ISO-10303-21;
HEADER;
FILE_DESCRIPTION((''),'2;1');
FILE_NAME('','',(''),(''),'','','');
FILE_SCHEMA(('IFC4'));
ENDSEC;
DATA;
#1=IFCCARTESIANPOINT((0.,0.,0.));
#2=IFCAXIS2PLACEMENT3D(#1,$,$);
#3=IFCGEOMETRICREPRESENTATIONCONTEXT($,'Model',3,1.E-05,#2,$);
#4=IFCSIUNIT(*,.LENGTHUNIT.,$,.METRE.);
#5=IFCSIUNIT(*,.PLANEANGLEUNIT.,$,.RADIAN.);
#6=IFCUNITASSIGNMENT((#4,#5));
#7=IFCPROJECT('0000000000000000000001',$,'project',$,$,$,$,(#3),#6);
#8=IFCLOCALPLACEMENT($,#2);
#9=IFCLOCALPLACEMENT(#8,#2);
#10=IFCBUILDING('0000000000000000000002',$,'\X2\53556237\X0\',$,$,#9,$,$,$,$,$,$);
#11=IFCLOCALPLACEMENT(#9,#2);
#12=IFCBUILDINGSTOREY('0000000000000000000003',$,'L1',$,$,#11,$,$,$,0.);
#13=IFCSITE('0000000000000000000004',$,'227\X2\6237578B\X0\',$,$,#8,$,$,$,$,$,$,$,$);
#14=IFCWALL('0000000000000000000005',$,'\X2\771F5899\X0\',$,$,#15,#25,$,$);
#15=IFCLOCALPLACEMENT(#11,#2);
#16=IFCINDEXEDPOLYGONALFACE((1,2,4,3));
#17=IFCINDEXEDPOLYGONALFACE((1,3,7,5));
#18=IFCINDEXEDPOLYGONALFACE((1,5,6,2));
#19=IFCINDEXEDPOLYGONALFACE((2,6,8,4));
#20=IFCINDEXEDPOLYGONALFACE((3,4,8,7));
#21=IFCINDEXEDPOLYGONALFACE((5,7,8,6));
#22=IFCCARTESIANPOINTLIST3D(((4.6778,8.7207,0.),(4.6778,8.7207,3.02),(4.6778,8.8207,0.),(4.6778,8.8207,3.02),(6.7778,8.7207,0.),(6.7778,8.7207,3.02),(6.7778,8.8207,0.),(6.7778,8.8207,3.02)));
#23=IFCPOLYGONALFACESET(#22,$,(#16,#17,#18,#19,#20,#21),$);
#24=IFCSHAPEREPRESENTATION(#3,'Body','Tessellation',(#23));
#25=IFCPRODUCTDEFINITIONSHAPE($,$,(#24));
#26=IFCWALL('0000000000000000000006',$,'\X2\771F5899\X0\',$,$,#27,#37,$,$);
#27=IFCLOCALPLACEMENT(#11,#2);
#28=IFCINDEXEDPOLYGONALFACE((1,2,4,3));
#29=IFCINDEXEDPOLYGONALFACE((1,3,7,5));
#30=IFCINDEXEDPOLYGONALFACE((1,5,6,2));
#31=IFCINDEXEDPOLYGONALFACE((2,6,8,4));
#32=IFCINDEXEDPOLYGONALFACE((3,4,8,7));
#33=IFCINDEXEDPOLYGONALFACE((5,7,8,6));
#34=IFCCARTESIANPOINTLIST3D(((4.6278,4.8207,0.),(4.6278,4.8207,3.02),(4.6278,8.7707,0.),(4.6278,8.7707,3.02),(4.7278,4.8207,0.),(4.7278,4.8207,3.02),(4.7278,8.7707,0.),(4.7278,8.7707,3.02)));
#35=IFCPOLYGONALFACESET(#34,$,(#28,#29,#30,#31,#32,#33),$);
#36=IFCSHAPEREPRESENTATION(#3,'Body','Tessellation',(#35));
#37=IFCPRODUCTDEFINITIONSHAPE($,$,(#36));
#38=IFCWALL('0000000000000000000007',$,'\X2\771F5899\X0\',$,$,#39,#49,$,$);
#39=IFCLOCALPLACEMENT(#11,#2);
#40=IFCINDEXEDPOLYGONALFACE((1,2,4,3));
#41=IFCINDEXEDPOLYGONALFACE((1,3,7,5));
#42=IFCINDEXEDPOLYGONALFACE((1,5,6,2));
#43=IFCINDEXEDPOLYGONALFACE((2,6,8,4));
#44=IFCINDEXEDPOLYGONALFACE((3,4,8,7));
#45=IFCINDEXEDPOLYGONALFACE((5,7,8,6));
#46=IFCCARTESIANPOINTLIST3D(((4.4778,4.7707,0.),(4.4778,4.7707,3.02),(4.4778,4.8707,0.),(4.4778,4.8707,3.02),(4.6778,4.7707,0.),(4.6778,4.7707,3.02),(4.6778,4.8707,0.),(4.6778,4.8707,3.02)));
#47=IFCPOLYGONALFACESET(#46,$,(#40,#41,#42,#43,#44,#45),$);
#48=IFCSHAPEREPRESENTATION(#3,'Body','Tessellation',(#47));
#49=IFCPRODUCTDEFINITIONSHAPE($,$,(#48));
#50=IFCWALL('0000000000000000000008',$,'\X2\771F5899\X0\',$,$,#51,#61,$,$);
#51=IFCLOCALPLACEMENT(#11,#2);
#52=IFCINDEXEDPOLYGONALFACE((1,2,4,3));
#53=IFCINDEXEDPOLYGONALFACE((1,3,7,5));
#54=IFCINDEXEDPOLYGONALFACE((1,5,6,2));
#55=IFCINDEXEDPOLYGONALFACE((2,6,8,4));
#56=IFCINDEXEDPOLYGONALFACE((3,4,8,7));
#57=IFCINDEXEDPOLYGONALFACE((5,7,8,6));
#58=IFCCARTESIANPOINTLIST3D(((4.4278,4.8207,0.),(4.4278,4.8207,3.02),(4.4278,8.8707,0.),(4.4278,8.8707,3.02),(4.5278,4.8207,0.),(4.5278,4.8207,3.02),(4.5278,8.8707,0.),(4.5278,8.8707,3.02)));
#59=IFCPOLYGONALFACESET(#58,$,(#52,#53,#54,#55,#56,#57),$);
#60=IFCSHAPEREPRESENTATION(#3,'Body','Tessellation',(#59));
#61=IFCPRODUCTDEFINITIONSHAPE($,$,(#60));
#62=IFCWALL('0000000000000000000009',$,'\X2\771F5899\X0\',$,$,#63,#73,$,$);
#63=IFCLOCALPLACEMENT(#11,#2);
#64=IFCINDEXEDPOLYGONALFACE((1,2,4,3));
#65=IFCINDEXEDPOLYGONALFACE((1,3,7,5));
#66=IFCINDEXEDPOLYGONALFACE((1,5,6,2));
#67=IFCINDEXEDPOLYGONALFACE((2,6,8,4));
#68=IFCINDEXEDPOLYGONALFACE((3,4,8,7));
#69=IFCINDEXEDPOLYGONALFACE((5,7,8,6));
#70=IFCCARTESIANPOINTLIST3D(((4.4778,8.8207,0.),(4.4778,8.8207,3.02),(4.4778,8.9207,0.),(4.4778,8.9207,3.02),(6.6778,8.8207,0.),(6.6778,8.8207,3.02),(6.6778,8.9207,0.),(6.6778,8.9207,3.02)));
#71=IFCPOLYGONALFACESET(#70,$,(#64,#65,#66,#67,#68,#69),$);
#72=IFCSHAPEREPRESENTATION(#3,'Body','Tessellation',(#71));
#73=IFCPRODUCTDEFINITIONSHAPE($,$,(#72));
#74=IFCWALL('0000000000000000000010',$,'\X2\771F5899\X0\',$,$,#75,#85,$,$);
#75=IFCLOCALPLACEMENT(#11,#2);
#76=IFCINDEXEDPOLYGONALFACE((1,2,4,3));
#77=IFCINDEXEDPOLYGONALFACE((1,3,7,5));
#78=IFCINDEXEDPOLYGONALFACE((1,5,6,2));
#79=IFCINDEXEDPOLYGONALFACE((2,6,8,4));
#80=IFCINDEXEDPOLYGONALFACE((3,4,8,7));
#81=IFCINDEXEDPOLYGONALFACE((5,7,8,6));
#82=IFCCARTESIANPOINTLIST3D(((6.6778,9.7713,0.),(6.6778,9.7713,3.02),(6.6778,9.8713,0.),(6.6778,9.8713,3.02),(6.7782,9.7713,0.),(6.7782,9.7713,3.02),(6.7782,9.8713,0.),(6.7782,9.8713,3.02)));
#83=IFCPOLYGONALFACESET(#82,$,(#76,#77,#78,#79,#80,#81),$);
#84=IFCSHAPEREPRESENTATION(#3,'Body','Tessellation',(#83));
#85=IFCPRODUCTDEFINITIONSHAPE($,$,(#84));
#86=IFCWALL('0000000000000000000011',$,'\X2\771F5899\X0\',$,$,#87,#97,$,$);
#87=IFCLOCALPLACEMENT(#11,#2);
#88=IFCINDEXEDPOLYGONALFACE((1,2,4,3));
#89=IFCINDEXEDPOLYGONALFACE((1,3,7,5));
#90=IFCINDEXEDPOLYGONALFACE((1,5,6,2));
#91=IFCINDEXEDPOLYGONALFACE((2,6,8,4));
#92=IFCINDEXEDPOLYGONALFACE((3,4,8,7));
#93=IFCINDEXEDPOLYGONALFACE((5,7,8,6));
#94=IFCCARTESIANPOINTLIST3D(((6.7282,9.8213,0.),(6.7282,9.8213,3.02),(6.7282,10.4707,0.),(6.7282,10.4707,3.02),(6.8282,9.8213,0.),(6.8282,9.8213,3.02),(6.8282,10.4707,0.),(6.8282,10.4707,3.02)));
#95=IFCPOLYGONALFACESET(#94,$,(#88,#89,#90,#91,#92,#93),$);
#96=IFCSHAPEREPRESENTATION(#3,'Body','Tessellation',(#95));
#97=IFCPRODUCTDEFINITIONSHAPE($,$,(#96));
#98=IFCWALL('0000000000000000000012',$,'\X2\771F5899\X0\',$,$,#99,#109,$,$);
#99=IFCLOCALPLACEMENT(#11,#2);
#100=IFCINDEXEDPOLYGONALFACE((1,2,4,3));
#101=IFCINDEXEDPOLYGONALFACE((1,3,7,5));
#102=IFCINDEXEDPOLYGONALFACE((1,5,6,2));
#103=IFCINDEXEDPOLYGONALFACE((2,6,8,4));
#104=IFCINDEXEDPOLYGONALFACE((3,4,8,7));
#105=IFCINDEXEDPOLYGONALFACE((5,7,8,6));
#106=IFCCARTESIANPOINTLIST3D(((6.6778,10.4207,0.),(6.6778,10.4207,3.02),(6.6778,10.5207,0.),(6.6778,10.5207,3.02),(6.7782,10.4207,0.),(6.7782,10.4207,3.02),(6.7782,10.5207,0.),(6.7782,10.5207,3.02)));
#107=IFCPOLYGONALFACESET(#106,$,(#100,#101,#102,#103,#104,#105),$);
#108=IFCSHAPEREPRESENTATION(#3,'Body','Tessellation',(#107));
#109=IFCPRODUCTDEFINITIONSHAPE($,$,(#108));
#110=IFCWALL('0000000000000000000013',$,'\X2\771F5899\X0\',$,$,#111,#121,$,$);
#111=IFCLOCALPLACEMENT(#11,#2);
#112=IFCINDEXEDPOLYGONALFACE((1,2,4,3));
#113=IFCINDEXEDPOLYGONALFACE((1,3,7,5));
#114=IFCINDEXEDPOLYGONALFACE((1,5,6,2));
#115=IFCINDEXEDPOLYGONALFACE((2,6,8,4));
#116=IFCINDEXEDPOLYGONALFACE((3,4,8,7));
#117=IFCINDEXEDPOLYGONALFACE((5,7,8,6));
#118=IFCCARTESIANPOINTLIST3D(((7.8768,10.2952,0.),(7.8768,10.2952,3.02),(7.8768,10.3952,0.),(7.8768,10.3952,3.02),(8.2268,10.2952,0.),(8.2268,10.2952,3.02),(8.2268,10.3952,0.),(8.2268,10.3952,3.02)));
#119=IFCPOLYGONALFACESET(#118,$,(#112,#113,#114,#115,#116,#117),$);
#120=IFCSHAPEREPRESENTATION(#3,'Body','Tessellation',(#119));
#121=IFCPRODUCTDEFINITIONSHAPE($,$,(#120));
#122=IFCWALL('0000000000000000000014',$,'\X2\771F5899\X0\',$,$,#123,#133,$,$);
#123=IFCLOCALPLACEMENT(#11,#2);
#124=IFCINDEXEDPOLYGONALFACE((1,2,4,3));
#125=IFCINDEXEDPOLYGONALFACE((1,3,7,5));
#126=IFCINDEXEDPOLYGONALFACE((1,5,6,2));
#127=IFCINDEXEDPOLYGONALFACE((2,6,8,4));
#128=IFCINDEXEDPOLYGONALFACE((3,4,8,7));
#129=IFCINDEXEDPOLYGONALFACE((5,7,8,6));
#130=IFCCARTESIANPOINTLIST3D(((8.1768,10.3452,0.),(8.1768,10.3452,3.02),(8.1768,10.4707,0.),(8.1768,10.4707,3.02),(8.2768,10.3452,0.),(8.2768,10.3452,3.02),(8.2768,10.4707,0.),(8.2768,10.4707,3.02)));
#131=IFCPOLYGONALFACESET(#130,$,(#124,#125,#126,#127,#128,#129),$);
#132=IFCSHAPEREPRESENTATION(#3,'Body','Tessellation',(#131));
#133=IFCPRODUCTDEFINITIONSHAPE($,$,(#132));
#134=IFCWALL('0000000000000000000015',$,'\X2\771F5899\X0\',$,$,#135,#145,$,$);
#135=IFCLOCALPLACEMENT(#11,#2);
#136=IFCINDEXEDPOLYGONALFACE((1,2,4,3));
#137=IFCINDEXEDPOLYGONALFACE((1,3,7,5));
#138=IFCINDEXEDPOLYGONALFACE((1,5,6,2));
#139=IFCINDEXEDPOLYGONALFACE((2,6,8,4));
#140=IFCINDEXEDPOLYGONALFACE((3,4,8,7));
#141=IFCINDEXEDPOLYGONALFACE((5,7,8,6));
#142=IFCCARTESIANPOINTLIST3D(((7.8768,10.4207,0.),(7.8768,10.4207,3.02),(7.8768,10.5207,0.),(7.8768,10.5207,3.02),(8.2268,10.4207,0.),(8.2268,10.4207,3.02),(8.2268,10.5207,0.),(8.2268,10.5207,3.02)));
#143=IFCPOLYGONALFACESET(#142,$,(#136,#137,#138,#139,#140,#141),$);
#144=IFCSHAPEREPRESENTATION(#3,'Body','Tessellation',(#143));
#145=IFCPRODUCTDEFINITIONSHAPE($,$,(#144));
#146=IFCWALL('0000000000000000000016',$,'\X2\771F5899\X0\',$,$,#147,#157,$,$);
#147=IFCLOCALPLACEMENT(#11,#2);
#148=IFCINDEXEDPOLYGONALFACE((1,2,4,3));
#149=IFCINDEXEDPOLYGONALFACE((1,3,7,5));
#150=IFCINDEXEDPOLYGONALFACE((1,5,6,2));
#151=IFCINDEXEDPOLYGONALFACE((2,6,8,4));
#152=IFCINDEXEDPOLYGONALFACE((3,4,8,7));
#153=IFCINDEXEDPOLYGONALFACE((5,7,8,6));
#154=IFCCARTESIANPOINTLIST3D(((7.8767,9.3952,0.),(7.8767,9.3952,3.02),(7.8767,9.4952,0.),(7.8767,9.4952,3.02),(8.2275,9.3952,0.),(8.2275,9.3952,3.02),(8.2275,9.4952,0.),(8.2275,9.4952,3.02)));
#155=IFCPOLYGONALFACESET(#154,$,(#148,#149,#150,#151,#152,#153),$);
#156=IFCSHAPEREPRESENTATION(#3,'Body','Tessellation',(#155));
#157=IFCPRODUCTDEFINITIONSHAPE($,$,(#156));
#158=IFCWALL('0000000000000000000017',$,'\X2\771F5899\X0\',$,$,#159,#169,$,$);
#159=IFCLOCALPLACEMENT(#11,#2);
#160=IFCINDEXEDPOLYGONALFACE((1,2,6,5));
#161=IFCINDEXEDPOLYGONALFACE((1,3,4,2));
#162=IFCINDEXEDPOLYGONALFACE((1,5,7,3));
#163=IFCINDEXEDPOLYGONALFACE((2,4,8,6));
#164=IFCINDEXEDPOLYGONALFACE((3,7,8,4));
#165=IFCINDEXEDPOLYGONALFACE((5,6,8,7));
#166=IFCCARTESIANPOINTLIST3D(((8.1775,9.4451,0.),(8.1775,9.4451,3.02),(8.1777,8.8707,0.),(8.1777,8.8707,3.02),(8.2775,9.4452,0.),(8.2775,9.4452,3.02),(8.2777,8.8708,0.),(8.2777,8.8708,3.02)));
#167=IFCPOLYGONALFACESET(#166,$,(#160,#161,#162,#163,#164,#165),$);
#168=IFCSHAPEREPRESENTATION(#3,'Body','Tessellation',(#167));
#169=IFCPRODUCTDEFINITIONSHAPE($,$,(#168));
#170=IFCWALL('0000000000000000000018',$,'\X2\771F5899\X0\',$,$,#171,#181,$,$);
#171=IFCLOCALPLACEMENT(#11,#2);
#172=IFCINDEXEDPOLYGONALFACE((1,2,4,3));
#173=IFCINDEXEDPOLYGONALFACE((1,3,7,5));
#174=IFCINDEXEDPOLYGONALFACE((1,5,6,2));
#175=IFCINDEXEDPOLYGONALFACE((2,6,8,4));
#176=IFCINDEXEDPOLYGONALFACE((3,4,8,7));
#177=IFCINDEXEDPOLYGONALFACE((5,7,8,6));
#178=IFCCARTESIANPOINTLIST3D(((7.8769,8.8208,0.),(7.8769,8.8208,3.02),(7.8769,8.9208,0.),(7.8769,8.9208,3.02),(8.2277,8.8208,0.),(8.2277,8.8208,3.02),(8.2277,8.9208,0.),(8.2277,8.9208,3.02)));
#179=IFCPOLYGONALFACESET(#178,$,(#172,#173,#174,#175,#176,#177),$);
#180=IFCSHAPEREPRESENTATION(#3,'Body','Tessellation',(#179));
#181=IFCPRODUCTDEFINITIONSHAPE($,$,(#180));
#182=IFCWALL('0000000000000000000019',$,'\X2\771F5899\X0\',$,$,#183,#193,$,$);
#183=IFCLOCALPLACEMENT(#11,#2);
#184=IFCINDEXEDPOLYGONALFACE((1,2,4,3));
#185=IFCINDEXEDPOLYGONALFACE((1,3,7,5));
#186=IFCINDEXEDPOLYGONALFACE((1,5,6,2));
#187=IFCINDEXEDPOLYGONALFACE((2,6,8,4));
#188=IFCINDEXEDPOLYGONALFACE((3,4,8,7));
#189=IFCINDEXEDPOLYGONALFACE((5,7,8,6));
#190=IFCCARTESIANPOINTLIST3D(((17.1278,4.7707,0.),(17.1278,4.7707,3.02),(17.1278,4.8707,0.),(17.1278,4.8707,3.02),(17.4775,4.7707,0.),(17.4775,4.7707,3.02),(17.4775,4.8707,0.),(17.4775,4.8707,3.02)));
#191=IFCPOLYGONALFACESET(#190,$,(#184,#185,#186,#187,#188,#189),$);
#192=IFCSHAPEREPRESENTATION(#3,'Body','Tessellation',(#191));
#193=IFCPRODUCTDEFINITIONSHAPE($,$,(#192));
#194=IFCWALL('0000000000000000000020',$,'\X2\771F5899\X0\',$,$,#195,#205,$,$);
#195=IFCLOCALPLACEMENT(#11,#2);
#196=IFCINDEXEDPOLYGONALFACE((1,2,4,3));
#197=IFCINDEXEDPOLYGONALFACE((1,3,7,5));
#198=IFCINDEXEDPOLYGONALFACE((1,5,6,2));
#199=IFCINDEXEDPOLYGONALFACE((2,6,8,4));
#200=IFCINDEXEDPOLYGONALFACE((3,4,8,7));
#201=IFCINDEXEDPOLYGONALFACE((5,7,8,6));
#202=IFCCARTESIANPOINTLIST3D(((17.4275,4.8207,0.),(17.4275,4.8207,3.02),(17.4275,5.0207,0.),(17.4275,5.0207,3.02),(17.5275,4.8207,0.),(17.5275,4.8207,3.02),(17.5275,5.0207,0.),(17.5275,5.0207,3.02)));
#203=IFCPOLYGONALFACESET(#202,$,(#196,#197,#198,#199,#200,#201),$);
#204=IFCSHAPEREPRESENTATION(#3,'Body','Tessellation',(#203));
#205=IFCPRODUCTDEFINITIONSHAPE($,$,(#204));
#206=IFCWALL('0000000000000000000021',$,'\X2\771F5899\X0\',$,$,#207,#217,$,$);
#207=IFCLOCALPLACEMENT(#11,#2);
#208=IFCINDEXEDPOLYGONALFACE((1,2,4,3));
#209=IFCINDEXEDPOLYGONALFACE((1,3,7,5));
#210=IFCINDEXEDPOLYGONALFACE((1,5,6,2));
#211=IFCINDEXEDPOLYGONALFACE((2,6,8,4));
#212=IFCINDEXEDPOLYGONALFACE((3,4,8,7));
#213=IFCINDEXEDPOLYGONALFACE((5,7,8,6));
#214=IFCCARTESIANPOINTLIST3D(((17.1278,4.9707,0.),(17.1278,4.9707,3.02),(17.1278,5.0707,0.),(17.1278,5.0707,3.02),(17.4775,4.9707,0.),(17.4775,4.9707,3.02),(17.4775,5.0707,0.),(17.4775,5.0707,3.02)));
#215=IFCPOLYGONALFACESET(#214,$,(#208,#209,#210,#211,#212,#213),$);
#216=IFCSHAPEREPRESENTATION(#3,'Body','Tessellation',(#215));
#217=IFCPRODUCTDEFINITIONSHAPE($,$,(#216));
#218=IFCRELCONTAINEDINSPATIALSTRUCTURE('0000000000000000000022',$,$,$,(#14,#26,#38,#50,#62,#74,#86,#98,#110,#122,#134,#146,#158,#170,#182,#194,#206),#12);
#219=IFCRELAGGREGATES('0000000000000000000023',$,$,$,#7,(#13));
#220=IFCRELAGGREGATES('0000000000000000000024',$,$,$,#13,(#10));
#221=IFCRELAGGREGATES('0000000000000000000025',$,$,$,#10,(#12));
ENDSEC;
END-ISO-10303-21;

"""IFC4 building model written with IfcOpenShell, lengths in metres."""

from ifc_helpers import new_model, si_unit, origin, place, context, project, spatial, polyline, outline, extrude, element, save


model = new_model("IFC4")

# Units and contexts
model_context = context("Model", 3, precision=1e-05, world=origin())
ifc_project = project(units=[si_unit("LENGTHUNIT", "METRE"), si_unit("PLANEANGLEUNIT", "RADIAN")], contexts=[model_context])

# Site, building, storey
site_placement = place(None, origin())
site = spatial("IfcSite", under=ifc_project, at=site_placement, Name="227户型")
building_placement = place(site_placement, origin())
building = spatial("IfcBuilding", under=site, at=building_placement, Name="单户")
storey_placement = place(building_placement, origin())
storey = spatial("IfcBuildingStorey", under=building, at=storey_placement, Name="L1", Elevation=0.0)

# Walls
wall_1_placement = place(storey_placement, origin())
element("IfcWall", 1, at=wall_1_placement, inside=storey, Name="真墙", context=model_context, shape_type="SweptSolid", body=[
    extrude(outline(polyline([(6.7778, 8.7207), (4.6778, 8.7207), (4.6778, 8.8207), (6.7778, 8.8207), (6.7778, 8.7207)])), origin(), (0.0, 0.0, 1.0), 3.02),
])
wall_2_placement = place(storey_placement, origin())
element("IfcWall", 2, at=wall_2_placement, inside=storey, Name="真墙", context=model_context, shape_type="SweptSolid", body=[
    extrude(outline(polyline([(4.7278, 8.7707), (4.7278, 4.8207), (4.6278, 4.8207), (4.6278, 8.7707), (4.7278, 8.7707)])), origin(), (0.0, 0.0, 1.0), 3.02),
])
wall_3_placement = place(storey_placement, origin())
element("IfcWall", 3, at=wall_3_placement, inside=storey, Name="真墙", context=model_context, shape_type="SweptSolid", body=[
    extrude(outline(polyline([(4.6778, 4.7707), (4.4778, 4.7707), (4.4778, 4.8707), (4.6778, 4.8707), (4.6778, 4.7707)])), origin(), (0.0, 0.0, 1.0), 3.02),
])
wall_4_placement = place(storey_placement, origin())
element("IfcWall", 4, at=wall_4_placement, inside=storey, Name="真墙", context=model_context, shape_type="SweptSolid", body=[
    extrude(outline(polyline([(4.4278, 4.8207), (4.4278, 8.8707), (4.5278, 8.8707), (4.5278, 4.8207), (4.4278, 4.8207)])), origin(), (0.0, 0.0, 1.0), 3.02),
])
wall_5_placement = place(storey_placement, origin())
element("IfcWall", 5, at=wall_5_placement, inside=storey, Name="真墙", context=model_context, shape_type="SweptSolid", body=[
    extrude(outline(polyline([(4.4778, 8.9207), (6.6778, 8.9207), (6.6778, 8.8207), (4.4778, 8.8207), (4.4778, 8.9207)])), origin(), (0.0, 0.0, 1.0), 3.02),
])
wall_6_placement = place(storey_placement, origin())
element("IfcWall", 6, at=wall_6_placement, inside=storey, Name="真墙", context=model_context, shape_type="SweptSolid", body=[
    extrude(outline(polyline([(6.6778, 9.8713), (6.7782, 9.8713), (6.7782, 9.7713), (6.6778, 9.7713), (6.6778, 9.8713)])), origin(), (0.0, 0.0, 1.0), 3.02),
])
wall_7_placement = place(storey_placement, origin())
element("IfcWall", 7, at=wall_7_placement, inside=storey, Name="真墙", context=model_context, shape_type="SweptSolid", body=[
    extrude(outline(polyline([(6.7282, 9.8213), (6.7282, 10.4707), (6.8282, 10.4707), (6.8282, 9.8213), (6.7282, 9.8213)])), origin(), (0.0, 0.0, 1.0), 3.02),
])
wall_8_placement = place(storey_placement, origin())
element("IfcWall", 8, at=wall_8_placement, inside=storey, Name="真墙", context=model_context, shape_type="SweptSolid", body=[
    extrude(outline(polyline([(6.7782, 10.4207), (6.6778, 10.4207), (6.6778, 10.5207), (6.7782, 10.5207), (6.7782, 10.4207)])), origin(), (0.0, 0.0, 1.0), 3.02),
])
wall_9_placement = place(storey_placement, origin())
element("IfcWall", 9, at=wall_9_placement, inside=storey, Name="真墙", context=model_context, shape_type="SweptSolid", body=[
    extrude(outline(polyline([(7.8768, 10.3952), (8.2268, 10.3952), (8.2268, 10.2952), (7.8768, 10.2952), (7.8768, 10.3952)])), origin(), (0.0, 0.0, 1.0), 3.02),
])
wall_10_placement = place(storey_placement, origin())
element("IfcWall", 10, at=wall_10_placement, inside=storey, Name="真墙", context=model_context, shape_type="SweptSolid", body=[
    extrude(outline(polyline([(8.1768, 10.3452), (8.1768, 10.4707), (8.2768, 10.4707), (8.2768, 10.3452), (8.1768, 10.3452)])), origin(), (0.0, 0.0, 1.0), 3.02),
])
wall_11_placement = place(storey_placement, origin())
element("IfcWall", 11, at=wall_11_placement, inside=storey, Name="真墙", context=model_context, shape_type="SweptSolid", body=[
    extrude(outline(polyline([(8.2268, 10.4207), (7.8768, 10.4207), (7.8768, 10.5207), (8.2268, 10.5207), (8.2268, 10.4207)])), origin(), (0.0, 0.0, 1.0), 3.02),
])
wall_12_placement = place(storey_placement, origin())
element("IfcWall", 12, at=wall_12_placement, inside=storey, Name="真墙", context=model_context, shape_type="SweptSolid", body=[
    extrude(outline(polyline([(7.8767, 9.4952), (8.2275, 9.4952), (8.2275, 9.3952), (7.8767, 9.3952), (7.8767, 9.4952)])), origin(), (0.0, 0.0, 1.0), 3.02),
])
wall_13_placement = place(storey_placement, origin())
element("IfcWall", 13, at=wall_13_placement, inside=storey, Name="真墙", context=model_context, shape_type="SweptSolid", body=[
    extrude(outline(polyline([(8.2775, 9.4452), (8.2777, 8.8708), (8.1777, 8.8707), (8.1775, 9.4451), (8.2775, 9.4452)])), origin(), (0.0, 0.0, 1.0), 3.02),
])
wall_14_placement = place(storey_placement, origin())
element("IfcWall", 14, at=wall_14_placement, inside=storey, Name="真墙", context=model_context, shape_type="SweptSolid", body=[
    extrude(outline(polyline([(8.2277, 8.8208), (7.8769, 8.8208), (7.8769, 8.9208), (8.2277, 8.9208), (8.2277, 8.8208)])), origin(), (0.0, 0.0, 1.0), 3.02),
])
wall_15_placement = place(storey_placement, origin())
element("IfcWall", 15, at=wall_15_placement, inside=storey, Name="真墙", context=model_context, shape_type="SweptSolid", body=[
    extrude(outline(polyline([(17.1278, 4.8707), (17.4775, 4.8707), (17.4775, 4.7707), (17.1278, 4.7707), (17.1278, 4.8707)])), origin(), (0.0, 0.0, 1.0), 3.02),
])
wall_16_placement = place(storey_placement, origin())
element("IfcWall", 16, at=wall_16_placement, inside=storey, Name="真墙", context=model_context, shape_type="SweptSolid", body=[
    extrude(outline(polyline([(17.4275, 4.8207), (17.4275, 5.0207), (17.5275, 5.0207), (17.5275, 4.8207), (17.4275, 4.8207)])), origin(), (0.0, 0.0, 1.0), 3.02),
])
wall_17_placement = place(storey_placement, origin())
element("IfcWall", 17, at=wall_17_placement, inside=storey, Name="真墙", context=model_context, shape_type="SweptSolid", body=[
    extrude(outline(polyline([(17.4775, 4.9707), (17.1278, 4.9707), (17.1278, 5.0707), (17.4775, 5.0707), (17.4775, 4.9707)])), origin(), (0.0, 0.0, 1.0), 3.02),
])

save(model, "model.ifc")
